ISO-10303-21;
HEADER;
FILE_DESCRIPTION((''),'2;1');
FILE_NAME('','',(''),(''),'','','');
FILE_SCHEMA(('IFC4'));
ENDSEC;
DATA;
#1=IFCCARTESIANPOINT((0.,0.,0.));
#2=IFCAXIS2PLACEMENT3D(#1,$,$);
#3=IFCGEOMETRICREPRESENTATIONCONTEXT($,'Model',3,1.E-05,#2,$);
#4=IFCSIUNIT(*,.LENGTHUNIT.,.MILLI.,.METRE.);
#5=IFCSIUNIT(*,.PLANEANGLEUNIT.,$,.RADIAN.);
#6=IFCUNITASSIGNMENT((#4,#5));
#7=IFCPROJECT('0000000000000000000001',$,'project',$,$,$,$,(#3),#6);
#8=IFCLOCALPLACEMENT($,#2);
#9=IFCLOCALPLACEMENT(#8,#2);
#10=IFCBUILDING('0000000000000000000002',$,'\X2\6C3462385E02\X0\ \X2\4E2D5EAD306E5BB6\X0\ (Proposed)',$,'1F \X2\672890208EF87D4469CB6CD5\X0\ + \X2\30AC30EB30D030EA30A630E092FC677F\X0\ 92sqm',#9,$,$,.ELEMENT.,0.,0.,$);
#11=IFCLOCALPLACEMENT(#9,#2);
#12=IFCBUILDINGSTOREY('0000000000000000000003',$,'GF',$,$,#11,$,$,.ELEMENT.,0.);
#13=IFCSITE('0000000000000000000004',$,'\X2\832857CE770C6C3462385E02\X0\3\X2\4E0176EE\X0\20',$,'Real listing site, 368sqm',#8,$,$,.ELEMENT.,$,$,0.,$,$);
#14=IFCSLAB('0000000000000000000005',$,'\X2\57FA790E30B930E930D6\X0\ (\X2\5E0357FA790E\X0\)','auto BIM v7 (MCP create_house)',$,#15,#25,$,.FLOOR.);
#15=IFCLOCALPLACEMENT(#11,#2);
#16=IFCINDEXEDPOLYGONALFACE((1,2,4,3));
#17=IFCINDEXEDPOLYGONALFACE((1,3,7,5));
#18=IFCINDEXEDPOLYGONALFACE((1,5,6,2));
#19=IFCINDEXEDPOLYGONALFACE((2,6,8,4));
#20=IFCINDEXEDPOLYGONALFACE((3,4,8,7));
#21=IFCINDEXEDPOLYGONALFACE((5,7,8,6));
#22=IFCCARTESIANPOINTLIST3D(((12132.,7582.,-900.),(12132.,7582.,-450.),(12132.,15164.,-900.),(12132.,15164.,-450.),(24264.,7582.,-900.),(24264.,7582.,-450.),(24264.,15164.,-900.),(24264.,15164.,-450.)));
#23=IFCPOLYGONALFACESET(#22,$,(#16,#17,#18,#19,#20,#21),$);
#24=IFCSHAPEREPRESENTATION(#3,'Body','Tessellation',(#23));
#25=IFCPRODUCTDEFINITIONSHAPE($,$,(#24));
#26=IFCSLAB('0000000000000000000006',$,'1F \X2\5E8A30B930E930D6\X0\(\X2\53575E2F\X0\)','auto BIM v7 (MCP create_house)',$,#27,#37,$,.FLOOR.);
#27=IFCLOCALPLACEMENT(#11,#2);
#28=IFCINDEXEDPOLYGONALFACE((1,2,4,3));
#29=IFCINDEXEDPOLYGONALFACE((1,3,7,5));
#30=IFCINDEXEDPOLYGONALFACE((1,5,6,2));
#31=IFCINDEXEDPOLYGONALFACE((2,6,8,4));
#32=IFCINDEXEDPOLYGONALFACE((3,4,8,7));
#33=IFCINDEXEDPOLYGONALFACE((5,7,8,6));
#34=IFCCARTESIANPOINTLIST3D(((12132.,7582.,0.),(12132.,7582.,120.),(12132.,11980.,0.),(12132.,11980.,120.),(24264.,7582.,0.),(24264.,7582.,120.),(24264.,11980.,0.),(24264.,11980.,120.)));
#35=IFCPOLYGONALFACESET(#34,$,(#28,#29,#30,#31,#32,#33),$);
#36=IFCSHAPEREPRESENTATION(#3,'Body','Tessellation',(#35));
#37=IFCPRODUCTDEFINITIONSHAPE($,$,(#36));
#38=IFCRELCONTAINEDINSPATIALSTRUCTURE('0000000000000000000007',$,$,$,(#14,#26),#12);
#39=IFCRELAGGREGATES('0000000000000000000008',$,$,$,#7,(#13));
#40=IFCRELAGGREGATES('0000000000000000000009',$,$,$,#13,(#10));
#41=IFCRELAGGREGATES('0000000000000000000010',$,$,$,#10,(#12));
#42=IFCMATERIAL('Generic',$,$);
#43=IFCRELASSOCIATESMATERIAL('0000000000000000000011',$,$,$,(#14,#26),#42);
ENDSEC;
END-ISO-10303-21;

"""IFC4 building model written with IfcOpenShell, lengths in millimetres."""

from ifc_helpers import new_model, si_unit, frame, frame_2d, origin, place, context, project, spatial, rectangle, extrude, material, element, save


model = new_model("IFC4")

# Units and contexts
model_context = context("Model", 3, precision=1e-05, world=origin())
ifc_project = project(units=[si_unit("LENGTHUNIT", "METRE", prefix="MILLI"), si_unit("PLANEANGLEUNIT", "RADIAN")], contexts=[model_context])

# Site, building, storey
site_placement = place(None, origin())
site = spatial("IfcSite", under=ifc_project, at=site_placement, Name="茨城県水戸市3丁目20", ObjectType="Real listing site, 368sqm", CompositionType="ELEMENT", RefElevation=0.0)
building_placement = place(site_placement, origin())
building = spatial("IfcBuilding", under=site, at=building_placement, Name="水戸市 中庭の家 (Proposed)", ObjectType="1F 木造軸組構法 + ガルバリウム鋼板 92sqm", CompositionType="ELEMENT", ElevationOfRefHeight=0.0, ElevationOfTerrain=0.0)
storey_placement = place(building_placement, origin())
storey = spatial("IfcBuildingStorey", under=building, at=storey_placement, Name="GF", CompositionType="ELEMENT", Elevation=0.0)

# Slabs
ifc_material = material(Name="Generic")
slab_1_placement = place(storey_placement, frame((6066.0, 3791.0, -450.0)))
element("IfcSlab", 1, at=slab_1_placement, inside=storey, material=ifc_material, Name="基礎スラブ (布基礎)", Description="auto BIM v7 (MCP create_house)", PredefinedType="FLOOR", context=model_context, shape_type="SweptSolid", body=[
    extrude(rectangle(XDim=12132.0, YDim=7582.0, at=frame_2d((6066.0, 3791.0))), frame((6066.0, 3791.0, -450.0)), (0.0, 0.0, 1.0), 450.0),
])
slab_2_placement = place(storey_placement, frame((6066.0, 3791.0, 0.0)))
element("IfcSlab", 2, at=slab_2_placement, inside=storey, material=ifc_material, Name="1F 床スラブ(南帯)", Description="auto BIM v7 (MCP create_house)", PredefinedType="FLOOR", context=model_context, shape_type="SweptSolid", body=[
    extrude(rectangle(XDim=12132.0, YDim=4398.0, at=frame_2d((6066.0, 2199.0))), frame((6066.0, 3791.0, 0.0)), (0.0, 0.0, 1.0), 120.0),
])

save(model, "model.ifc")
